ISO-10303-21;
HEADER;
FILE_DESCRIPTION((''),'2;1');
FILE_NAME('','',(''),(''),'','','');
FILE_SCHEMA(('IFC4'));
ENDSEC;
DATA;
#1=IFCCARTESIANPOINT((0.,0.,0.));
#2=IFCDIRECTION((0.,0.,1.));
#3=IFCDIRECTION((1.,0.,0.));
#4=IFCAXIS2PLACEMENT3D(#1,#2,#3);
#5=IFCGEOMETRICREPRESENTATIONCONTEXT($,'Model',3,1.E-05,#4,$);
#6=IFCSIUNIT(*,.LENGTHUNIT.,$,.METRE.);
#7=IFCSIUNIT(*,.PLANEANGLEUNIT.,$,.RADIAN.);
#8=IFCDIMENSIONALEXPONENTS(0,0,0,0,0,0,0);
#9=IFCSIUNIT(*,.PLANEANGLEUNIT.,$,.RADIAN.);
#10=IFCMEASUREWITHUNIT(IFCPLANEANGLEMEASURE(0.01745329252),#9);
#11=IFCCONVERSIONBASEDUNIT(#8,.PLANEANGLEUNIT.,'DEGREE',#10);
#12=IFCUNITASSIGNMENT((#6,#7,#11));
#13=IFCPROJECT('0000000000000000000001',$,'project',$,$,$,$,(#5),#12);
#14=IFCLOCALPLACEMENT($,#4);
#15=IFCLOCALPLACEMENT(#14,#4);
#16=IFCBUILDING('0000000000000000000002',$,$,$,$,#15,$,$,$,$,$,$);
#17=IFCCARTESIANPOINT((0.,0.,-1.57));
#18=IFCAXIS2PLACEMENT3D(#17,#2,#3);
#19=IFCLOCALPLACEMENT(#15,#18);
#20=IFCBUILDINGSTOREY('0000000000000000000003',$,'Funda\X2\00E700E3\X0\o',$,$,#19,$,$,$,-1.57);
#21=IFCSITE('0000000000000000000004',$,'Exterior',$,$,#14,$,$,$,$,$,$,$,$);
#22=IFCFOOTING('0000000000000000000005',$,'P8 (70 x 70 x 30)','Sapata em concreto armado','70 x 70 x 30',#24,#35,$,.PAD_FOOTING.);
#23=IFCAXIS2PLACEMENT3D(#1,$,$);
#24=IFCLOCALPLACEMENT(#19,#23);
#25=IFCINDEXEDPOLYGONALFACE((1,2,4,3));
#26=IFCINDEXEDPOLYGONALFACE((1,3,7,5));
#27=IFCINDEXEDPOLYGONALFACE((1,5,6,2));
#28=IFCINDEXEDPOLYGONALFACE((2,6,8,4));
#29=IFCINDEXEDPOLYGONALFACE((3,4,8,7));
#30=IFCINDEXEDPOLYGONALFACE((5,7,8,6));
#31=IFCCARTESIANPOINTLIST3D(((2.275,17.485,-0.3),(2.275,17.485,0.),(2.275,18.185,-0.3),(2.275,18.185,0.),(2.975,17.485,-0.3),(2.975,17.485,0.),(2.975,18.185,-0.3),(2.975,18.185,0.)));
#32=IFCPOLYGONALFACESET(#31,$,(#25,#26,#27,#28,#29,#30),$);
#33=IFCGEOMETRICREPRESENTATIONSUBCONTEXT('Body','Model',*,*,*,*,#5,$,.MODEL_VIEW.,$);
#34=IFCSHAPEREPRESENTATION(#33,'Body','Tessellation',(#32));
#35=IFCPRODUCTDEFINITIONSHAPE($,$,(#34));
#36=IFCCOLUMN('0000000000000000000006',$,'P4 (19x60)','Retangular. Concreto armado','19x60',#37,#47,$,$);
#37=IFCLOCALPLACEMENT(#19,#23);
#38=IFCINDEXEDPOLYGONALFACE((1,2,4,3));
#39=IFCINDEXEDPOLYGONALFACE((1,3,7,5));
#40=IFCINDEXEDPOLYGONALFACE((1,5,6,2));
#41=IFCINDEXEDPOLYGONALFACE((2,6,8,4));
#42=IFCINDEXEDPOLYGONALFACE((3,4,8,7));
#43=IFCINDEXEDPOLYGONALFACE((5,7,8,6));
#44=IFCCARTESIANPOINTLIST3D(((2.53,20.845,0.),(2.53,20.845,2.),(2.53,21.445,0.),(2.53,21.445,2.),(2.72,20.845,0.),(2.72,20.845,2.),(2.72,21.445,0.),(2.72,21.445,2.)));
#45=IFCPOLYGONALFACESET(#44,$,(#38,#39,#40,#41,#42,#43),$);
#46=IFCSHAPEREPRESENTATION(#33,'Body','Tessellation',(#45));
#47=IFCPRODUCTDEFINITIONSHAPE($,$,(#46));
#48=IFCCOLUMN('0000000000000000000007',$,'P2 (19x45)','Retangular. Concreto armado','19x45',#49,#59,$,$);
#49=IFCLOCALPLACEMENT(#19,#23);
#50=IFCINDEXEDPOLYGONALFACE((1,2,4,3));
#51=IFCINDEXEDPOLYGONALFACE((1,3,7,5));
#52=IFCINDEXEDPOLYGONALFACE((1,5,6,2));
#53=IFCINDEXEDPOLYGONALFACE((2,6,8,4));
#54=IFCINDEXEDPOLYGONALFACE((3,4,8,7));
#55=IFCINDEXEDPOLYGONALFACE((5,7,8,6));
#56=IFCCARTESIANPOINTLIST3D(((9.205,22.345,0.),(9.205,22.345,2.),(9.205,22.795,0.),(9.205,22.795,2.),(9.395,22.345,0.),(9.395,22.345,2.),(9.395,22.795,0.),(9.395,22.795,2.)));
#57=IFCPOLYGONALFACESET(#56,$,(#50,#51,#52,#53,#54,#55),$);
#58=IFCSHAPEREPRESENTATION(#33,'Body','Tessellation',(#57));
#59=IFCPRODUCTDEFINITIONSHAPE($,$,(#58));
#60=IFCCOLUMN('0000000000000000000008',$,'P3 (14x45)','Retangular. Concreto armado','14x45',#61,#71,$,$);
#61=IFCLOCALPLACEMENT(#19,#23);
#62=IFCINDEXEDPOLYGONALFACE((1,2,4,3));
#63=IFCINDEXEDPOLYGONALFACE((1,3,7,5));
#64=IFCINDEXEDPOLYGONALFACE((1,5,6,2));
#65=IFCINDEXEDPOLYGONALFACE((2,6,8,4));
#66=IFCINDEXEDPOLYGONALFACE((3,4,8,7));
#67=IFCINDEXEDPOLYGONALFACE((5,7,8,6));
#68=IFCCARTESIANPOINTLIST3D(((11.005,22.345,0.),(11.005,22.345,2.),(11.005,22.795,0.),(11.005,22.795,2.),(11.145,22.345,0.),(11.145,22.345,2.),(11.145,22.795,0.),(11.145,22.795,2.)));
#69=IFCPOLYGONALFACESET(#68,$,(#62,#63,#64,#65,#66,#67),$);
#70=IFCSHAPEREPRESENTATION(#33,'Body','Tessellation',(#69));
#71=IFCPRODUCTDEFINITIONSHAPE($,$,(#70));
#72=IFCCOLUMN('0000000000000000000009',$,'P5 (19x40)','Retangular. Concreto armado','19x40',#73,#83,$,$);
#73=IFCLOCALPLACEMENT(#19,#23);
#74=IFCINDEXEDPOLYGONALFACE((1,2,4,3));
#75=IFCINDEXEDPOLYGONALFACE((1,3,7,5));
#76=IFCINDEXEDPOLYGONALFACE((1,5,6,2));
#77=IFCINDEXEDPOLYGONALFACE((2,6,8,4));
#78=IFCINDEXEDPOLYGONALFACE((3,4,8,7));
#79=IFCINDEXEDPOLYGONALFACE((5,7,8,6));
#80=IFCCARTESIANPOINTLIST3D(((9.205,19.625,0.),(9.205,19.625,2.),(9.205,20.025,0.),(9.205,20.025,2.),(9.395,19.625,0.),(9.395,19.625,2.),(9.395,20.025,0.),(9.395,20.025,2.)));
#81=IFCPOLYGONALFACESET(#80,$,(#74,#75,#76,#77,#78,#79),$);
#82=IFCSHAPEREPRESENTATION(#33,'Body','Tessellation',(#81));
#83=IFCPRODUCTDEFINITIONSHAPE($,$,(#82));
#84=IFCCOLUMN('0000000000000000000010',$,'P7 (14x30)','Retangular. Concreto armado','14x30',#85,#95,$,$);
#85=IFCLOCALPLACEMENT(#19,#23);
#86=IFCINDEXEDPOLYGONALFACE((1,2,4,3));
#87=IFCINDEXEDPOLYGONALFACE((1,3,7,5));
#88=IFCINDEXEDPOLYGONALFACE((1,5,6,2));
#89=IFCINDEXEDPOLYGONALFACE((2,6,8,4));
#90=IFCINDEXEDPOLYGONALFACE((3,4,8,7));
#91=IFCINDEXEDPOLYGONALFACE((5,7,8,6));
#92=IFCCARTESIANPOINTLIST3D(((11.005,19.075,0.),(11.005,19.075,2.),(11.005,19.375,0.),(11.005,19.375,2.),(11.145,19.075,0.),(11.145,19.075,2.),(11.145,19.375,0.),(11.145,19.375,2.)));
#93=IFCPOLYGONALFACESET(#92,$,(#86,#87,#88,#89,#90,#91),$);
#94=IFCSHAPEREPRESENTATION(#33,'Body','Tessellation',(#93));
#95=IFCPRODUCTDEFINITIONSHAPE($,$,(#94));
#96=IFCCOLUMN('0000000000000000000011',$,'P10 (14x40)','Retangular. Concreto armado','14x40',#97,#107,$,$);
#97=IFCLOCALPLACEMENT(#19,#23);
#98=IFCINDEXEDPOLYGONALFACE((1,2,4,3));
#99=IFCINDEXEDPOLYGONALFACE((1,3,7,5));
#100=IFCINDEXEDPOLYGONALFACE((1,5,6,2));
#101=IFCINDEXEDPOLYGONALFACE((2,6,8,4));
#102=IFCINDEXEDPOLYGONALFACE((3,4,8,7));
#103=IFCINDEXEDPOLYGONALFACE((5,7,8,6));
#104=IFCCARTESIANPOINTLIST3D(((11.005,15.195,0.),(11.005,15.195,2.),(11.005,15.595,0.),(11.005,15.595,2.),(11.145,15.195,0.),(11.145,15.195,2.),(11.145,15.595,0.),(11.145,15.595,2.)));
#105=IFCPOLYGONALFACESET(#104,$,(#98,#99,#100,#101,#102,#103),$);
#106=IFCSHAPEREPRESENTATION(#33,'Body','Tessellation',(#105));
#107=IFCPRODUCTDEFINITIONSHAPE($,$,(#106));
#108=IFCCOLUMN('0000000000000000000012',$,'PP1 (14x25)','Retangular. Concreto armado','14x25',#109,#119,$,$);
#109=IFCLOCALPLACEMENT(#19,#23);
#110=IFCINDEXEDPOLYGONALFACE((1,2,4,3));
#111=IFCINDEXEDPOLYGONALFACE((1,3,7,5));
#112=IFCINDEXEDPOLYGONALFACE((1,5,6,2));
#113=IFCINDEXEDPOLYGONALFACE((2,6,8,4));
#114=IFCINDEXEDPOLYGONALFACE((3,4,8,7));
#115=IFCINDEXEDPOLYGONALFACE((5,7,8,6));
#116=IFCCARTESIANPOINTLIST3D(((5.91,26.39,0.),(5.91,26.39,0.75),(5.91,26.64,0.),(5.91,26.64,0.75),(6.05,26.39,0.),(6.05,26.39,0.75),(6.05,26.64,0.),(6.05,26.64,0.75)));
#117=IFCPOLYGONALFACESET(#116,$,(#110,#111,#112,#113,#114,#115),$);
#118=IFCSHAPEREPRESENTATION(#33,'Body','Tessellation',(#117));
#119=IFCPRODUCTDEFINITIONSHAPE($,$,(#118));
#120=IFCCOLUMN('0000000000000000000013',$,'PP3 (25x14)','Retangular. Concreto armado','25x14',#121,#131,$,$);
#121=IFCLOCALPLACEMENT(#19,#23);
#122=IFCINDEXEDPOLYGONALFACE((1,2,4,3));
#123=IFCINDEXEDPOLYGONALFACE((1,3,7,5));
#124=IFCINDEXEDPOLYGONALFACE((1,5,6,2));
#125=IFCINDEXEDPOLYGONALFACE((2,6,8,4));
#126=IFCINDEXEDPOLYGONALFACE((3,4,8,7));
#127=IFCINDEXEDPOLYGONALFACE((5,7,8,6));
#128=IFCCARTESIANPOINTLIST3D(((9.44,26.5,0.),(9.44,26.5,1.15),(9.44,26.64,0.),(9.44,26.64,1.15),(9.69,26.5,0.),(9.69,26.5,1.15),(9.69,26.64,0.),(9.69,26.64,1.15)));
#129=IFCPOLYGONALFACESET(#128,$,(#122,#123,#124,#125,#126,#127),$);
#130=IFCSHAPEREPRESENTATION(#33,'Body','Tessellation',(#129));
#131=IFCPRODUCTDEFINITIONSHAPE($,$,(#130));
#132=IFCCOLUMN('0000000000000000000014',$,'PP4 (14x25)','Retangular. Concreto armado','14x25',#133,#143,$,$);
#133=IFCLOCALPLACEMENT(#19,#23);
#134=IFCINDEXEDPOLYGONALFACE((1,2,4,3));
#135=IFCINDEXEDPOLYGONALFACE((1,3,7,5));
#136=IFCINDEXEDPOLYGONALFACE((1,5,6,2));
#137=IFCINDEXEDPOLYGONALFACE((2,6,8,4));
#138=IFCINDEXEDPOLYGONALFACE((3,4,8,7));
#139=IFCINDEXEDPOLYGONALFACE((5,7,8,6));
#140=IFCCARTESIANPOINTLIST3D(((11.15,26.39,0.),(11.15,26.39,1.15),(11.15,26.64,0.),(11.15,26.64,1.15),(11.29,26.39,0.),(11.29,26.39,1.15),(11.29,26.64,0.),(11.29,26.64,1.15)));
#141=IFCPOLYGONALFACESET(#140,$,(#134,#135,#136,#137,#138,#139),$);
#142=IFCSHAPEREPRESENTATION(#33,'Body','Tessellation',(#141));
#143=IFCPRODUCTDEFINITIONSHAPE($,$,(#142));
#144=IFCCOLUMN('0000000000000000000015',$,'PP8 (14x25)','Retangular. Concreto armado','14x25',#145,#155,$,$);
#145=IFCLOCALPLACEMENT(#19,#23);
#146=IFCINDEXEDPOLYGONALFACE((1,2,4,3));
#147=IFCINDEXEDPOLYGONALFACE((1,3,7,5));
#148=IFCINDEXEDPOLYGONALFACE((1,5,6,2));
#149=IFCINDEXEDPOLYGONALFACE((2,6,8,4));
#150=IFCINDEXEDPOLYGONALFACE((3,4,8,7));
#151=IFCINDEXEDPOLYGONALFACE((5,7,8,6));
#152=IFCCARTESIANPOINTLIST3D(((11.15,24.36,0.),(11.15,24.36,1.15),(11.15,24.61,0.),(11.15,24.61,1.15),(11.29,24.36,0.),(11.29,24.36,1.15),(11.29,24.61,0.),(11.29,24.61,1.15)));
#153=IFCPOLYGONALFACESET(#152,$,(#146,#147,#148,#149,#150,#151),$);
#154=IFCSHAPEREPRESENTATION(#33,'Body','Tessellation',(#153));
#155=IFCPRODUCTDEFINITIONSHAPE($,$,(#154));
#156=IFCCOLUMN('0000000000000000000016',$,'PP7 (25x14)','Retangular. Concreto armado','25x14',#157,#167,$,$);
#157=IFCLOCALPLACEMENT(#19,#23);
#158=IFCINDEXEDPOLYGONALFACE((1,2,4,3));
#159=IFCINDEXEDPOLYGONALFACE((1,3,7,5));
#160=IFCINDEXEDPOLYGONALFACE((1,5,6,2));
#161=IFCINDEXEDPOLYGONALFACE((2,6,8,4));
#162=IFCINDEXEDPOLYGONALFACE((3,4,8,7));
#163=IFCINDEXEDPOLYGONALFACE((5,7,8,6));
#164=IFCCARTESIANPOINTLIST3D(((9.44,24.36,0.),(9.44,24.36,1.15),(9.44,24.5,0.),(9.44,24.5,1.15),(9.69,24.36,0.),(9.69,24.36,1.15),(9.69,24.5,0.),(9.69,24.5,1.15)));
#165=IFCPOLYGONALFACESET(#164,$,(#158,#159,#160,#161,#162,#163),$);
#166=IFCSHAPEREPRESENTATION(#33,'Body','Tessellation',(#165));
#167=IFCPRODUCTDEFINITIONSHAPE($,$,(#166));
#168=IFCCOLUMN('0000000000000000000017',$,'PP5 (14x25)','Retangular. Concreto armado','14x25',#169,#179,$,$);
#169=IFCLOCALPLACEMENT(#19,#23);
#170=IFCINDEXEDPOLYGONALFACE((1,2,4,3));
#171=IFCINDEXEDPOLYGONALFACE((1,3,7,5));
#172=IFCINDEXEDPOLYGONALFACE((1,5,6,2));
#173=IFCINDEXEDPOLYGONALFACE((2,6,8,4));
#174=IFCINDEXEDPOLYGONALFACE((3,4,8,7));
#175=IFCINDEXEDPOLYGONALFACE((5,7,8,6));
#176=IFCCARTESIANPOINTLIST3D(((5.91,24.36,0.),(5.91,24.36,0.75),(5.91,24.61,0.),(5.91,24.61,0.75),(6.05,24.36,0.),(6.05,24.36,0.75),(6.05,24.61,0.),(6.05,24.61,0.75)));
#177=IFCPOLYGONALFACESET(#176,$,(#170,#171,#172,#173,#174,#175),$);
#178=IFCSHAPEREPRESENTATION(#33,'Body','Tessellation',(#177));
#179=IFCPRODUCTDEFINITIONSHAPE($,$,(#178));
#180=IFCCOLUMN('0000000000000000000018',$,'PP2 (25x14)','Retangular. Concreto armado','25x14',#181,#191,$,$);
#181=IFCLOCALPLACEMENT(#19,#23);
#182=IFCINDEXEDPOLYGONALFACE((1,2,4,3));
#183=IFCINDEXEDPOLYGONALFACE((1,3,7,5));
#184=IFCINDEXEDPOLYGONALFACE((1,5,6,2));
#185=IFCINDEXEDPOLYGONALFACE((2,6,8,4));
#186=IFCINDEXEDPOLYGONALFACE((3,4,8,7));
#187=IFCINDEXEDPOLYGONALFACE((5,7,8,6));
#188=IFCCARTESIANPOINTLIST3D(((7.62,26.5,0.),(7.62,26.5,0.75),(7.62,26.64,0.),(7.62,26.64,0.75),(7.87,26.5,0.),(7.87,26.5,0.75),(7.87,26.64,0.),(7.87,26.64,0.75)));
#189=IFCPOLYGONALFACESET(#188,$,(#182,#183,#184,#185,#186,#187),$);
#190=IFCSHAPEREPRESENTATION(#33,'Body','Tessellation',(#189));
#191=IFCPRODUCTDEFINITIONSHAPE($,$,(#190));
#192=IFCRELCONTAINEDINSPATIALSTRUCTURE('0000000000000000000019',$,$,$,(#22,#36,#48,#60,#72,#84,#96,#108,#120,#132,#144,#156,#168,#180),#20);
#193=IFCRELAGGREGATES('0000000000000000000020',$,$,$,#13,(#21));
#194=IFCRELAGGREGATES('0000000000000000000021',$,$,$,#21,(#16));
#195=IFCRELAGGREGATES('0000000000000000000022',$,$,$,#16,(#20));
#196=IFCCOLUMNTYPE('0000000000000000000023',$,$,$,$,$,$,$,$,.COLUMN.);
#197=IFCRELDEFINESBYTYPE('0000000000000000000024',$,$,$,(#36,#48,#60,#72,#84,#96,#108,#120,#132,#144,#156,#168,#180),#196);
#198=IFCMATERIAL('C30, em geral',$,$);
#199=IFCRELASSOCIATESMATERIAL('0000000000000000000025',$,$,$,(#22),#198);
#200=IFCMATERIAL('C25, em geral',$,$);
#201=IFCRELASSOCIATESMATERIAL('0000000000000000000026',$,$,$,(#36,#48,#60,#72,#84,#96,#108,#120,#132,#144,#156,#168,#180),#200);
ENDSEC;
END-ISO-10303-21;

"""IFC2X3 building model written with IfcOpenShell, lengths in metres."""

from ifc_helpers import new_model, entity, si_unit, converted_unit, frame, frame_2d, origin_with_axes, origin_2d_with_axis, place, context, subcontext, project, spatial, rectangle, extrude, material, type_object, element, save


model = new_model("IFC2X3")

# Units and contexts
model_context = context("Model", 3, precision=1e-05, world=origin_with_axes())
body_context = subcontext(model_context, "Body", "Model", "MODEL_VIEW")
ifc_project = project(units=[si_unit("LENGTHUNIT", "METRE"), si_unit("PLANEANGLEUNIT", "RADIAN"), converted_unit("PLANEANGLEUNIT", "DEGREE", entity("IfcPlaneAngleMeasure", 0.01745329252), si_unit("PLANEANGLEUNIT", "RADIAN"), dimensions=[0, 0, 0, 0, 0, 0, 0])], contexts=[model_context])

# Site, building, storey
site_placement = place(None, origin_with_axes())
site = spatial("IfcSite", under=ifc_project, at=site_placement, Name="Exterior")
building_placement = place(site_placement, origin_with_axes())
building = spatial("IfcBuilding", under=site, at=building_placement)
storey_placement = place(building_placement, frame((0.0, 0.0, -1.57), z_axis=(0.0, 0.0, 1.0), x_axis=(1.0, 0.0, 0.0)))
storey = spatial("IfcBuildingStorey", under=building, at=storey_placement, Name="Fundação", Elevation=-1.57)

# Footing
ifc_material_1 = material(Name="C30, em geral")
footing_1_placement = place(storey_placement, frame((2.625, 17.835, -0.3), z_axis=(0.0, 0.0, 1.0), x_axis=(1.0, 0.0, 0.0)))
element("IfcFooting", 1, at=footing_1_placement, inside=storey, material=ifc_material_1, Name="P8 (70 x 70 x 30)", Description="Sapata em concreto armado", ObjectType="70 x 70 x 30", PredefinedType="PAD_FOOTING", context=body_context, shape_type="SweptSolid", body=[
    extrude(rectangle(XDim=0.7, YDim=0.7, at=origin_2d_with_axis()), origin_with_axes(), (0.0, 0.0, 1.0), 0.3),
])

# Columns
ifc_material_2 = material(Name="C25, em geral")
column_type = type_object("IfcColumnType", PredefinedType="COLUMN")
column_1_placement = place(storey_placement, frame((2.53, 21.445, 0.0), z_axis=(0.0, 0.0, 1.0), x_axis=(1.0, 0.0, 0.0)))
element("IfcColumn", 2, at=column_1_placement, inside=storey, type_object=column_type, material=ifc_material_2, Name="P4 (19x60)", Description="Retangular. Concreto armado", ObjectType="19x60", context=body_context, shape_type="SweptSolid", body=[
    extrude(rectangle(XDim=0.19, YDim=0.6, at=frame_2d((0.095, -0.3), x_axis=(1.0, 0.0))), origin_with_axes(), (0.0, 0.0, 1.0), 2.0),
])
column_2_placement = place(storey_placement, frame((9.395, 22.345, 0.0), z_axis=(0.0, 0.0, 1.0), x_axis=(1.0, 0.0, 0.0)))
element("IfcColumn", 3, at=column_2_placement, inside=storey, type_object=column_type, material=ifc_material_2, Name="P2 (19x45)", Description="Retangular. Concreto armado", ObjectType="19x45", context=body_context, shape_type="SweptSolid", body=[
    extrude(rectangle(XDim=0.19, YDim=0.45, at=frame_2d((-0.095, 0.225), x_axis=(1.0, 0.0))), origin_with_axes(), (0.0, 0.0, 1.0), 2.0),
])
column_3_placement = place(storey_placement, frame((11.145, 22.345, 0.0), z_axis=(0.0, 0.0, 1.0), x_axis=(1.0, 0.0, 0.0)))
element("IfcColumn", 4, at=column_3_placement, inside=storey, type_object=column_type, material=ifc_material_2, Name="P3 (14x45)", Description="Retangular. Concreto armado", ObjectType="14x45", context=body_context, shape_type="SweptSolid", body=[
    extrude(rectangle(XDim=0.14, YDim=0.45, at=frame_2d((-0.07, 0.225), x_axis=(1.0, 0.0))), origin_with_axes(), (0.0, 0.0, 1.0), 2.0),
])
column_4_placement = place(storey_placement, frame((9.395, 19.625, 0.0), z_axis=(0.0, 0.0, 1.0), x_axis=(1.0, 0.0, 0.0)))
element("IfcColumn", 5, at=column_4_placement, inside=storey, type_object=column_type, material=ifc_material_2, Name="P5 (19x40)", Description="Retangular. Concreto armado", ObjectType="19x40", context=body_context, shape_type="SweptSolid", body=[
    extrude(rectangle(XDim=0.19, YDim=0.4, at=frame_2d((-0.095, 0.2), x_axis=(1.0, 0.0))), origin_with_axes(), (0.0, 0.0, 1.0), 2.0),
])
column_5_placement = place(storey_placement, frame((11.005, 19.375, 0.0), z_axis=(0.0, 0.0, 1.0), x_axis=(1.0, 0.0, 0.0)))
element("IfcColumn", 6, at=column_5_placement, inside=storey, type_object=column_type, material=ifc_material_2, Name="P7 (14x30)", Description="Retangular. Concreto armado", ObjectType="14x30", context=body_context, shape_type="SweptSolid", body=[
    extrude(rectangle(XDim=0.14, YDim=0.3, at=frame_2d((0.07, -0.15), x_axis=(1.0, 0.0))), origin_with_axes(), (0.0, 0.0, 1.0), 2.0),
])
column_6_placement = place(storey_placement, frame((11.145, 15.595, 0.0), z_axis=(0.0, 0.0, 1.0), x_axis=(1.0, 0.0, 0.0)))
element("IfcColumn", 7, at=column_6_placement, inside=storey, type_object=column_type, material=ifc_material_2, Name="P10 (14x40)", Description="Retangular. Concreto armado", ObjectType="14x40", context=body_context, shape_type="SweptSolid", body=[
    extrude(rectangle(XDim=0.14, YDim=0.4, at=frame_2d((-0.07, -0.2), x_axis=(1.0, 0.0))), origin_with_axes(), (0.0, 0.0, 1.0), 2.0),
])
column_7_placement = place(storey_placement, frame((6.05, 26.64, 0.0), z_axis=(0.0, 0.0, 1.0), x_axis=(1.0, 0.0, 0.0)))
element("IfcColumn", 8, at=column_7_placement, inside=storey, type_object=column_type, material=ifc_material_2, Name="PP1 (14x25)", Description="Retangular. Concreto armado", ObjectType="14x25", context=body_context, shape_type="SweptSolid", body=[
    extrude(rectangle(XDim=0.14, YDim=0.25, at=frame_2d((-0.07, -0.125), x_axis=(1.0, 0.0))), origin_with_axes(), (0.0, 0.0, 1.0), 0.75),
])
column_8_placement = place(storey_placement, frame((9.69, 26.5, 0.0), z_axis=(0.0, 0.0, 1.0), x_axis=(1.0, 0.0, 0.0)))
element("IfcColumn", 9, at=column_8_placement, inside=storey, type_object=column_type, material=ifc_material_2, Name="PP3 (25x14)", Description="Retangular. Concreto armado", ObjectType="25x14", context=body_context, shape_type="SweptSolid", body=[
    extrude(rectangle(XDim=0.25, YDim=0.14, at=frame_2d((-0.125, 0.07), x_axis=(1.0, 0.0))), origin_with_axes(), (0.0, 0.0, 1.0), 1.15),
])
column_9_placement = place(storey_placement, frame((11.15, 26.64, 0.0), z_axis=(0.0, 0.0, 1.0), x_axis=(1.0, 0.0, 0.0)))
element("IfcColumn", 10, at=column_9_placement, inside=storey, type_object=column_type, material=ifc_material_2, Name="PP4 (14x25)", Description="Retangular. Concreto armado", ObjectType="14x25", context=body_context, shape_type="SweptSolid", body=[
    extrude(rectangle(XDim=0.14, YDim=0.25, at=frame_2d((0.07, -0.125), x_axis=(1.0, 0.0))), origin_with_axes(), (0.0, 0.0, 1.0), 1.15),
])
column_10_placement = place(storey_placement, frame((11.15, 24.36, 0.0), z_axis=(0.0, 0.0, 1.0), x_axis=(1.0, 0.0, 0.0)))
element("IfcColumn", 11, at=column_10_placement, inside=storey, type_object=column_type, material=ifc_material_2, Name="PP8 (14x25)", Description="Retangular. Concreto armado", ObjectType="14x25", context=body_context, shape_type="SweptSolid", body=[
    extrude(rectangle(XDim=0.14, YDim=0.25, at=frame_2d((0.07, 0.125), x_axis=(1.0, 0.0))), origin_with_axes(), (0.0, 0.0, 1.0), 1.15),
])
column_11_placement = place(storey_placement, frame((9.69, 24.5, 0.0), z_axis=(0.0, 0.0, 1.0), x_axis=(1.0, 0.0, 0.0)))
element("IfcColumn", 12, at=column_11_placement, inside=storey, type_object=column_type, material=ifc_material_2, Name="PP7 (25x14)", Description="Retangular. Concreto armado", ObjectType="25x14", context=body_context, shape_type="SweptSolid", body=[
    extrude(rectangle(XDim=0.25, YDim=0.14, at=frame_2d((-0.125, -0.07), x_axis=(1.0, 0.0))), origin_with_axes(), (0.0, 0.0, 1.0), 1.15),
])
column_12_placement = place(storey_placement, frame((6.05, 24.36, 0.0), z_axis=(0.0, 0.0, 1.0), x_axis=(1.0, 0.0, 0.0)))
element("IfcColumn", 13, at=column_12_placement, inside=storey, type_object=column_type, material=ifc_material_2, Name="PP5 (14x25)", Description="Retangular. Concreto armado", ObjectType="14x25", context=body_context, shape_type="SweptSolid", body=[
    extrude(rectangle(XDim=0.14, YDim=0.25, at=frame_2d((-0.07, 0.125), x_axis=(1.0, 0.0))), origin_with_axes(), (0.0, 0.0, 1.0), 0.75),
])
column_13_placement = place(storey_placement, frame((7.87, 26.5, 0.0), z_axis=(0.0, 0.0, 1.0), x_axis=(1.0, 0.0, 0.0)))
element("IfcColumn", 14, at=column_13_placement, inside=storey, type_object=column_type, material=ifc_material_2, Name="PP2 (25x14)", Description="Retangular. Concreto armado", ObjectType="25x14", context=body_context, shape_type="SweptSolid", body=[
    extrude(rectangle(XDim=0.25, YDim=0.14, at=frame_2d((-0.125, 0.07), x_axis=(1.0, 0.0))), origin_with_axes(), (0.0, 0.0, 1.0), 0.75),
])

save(model, "model.ifc")
